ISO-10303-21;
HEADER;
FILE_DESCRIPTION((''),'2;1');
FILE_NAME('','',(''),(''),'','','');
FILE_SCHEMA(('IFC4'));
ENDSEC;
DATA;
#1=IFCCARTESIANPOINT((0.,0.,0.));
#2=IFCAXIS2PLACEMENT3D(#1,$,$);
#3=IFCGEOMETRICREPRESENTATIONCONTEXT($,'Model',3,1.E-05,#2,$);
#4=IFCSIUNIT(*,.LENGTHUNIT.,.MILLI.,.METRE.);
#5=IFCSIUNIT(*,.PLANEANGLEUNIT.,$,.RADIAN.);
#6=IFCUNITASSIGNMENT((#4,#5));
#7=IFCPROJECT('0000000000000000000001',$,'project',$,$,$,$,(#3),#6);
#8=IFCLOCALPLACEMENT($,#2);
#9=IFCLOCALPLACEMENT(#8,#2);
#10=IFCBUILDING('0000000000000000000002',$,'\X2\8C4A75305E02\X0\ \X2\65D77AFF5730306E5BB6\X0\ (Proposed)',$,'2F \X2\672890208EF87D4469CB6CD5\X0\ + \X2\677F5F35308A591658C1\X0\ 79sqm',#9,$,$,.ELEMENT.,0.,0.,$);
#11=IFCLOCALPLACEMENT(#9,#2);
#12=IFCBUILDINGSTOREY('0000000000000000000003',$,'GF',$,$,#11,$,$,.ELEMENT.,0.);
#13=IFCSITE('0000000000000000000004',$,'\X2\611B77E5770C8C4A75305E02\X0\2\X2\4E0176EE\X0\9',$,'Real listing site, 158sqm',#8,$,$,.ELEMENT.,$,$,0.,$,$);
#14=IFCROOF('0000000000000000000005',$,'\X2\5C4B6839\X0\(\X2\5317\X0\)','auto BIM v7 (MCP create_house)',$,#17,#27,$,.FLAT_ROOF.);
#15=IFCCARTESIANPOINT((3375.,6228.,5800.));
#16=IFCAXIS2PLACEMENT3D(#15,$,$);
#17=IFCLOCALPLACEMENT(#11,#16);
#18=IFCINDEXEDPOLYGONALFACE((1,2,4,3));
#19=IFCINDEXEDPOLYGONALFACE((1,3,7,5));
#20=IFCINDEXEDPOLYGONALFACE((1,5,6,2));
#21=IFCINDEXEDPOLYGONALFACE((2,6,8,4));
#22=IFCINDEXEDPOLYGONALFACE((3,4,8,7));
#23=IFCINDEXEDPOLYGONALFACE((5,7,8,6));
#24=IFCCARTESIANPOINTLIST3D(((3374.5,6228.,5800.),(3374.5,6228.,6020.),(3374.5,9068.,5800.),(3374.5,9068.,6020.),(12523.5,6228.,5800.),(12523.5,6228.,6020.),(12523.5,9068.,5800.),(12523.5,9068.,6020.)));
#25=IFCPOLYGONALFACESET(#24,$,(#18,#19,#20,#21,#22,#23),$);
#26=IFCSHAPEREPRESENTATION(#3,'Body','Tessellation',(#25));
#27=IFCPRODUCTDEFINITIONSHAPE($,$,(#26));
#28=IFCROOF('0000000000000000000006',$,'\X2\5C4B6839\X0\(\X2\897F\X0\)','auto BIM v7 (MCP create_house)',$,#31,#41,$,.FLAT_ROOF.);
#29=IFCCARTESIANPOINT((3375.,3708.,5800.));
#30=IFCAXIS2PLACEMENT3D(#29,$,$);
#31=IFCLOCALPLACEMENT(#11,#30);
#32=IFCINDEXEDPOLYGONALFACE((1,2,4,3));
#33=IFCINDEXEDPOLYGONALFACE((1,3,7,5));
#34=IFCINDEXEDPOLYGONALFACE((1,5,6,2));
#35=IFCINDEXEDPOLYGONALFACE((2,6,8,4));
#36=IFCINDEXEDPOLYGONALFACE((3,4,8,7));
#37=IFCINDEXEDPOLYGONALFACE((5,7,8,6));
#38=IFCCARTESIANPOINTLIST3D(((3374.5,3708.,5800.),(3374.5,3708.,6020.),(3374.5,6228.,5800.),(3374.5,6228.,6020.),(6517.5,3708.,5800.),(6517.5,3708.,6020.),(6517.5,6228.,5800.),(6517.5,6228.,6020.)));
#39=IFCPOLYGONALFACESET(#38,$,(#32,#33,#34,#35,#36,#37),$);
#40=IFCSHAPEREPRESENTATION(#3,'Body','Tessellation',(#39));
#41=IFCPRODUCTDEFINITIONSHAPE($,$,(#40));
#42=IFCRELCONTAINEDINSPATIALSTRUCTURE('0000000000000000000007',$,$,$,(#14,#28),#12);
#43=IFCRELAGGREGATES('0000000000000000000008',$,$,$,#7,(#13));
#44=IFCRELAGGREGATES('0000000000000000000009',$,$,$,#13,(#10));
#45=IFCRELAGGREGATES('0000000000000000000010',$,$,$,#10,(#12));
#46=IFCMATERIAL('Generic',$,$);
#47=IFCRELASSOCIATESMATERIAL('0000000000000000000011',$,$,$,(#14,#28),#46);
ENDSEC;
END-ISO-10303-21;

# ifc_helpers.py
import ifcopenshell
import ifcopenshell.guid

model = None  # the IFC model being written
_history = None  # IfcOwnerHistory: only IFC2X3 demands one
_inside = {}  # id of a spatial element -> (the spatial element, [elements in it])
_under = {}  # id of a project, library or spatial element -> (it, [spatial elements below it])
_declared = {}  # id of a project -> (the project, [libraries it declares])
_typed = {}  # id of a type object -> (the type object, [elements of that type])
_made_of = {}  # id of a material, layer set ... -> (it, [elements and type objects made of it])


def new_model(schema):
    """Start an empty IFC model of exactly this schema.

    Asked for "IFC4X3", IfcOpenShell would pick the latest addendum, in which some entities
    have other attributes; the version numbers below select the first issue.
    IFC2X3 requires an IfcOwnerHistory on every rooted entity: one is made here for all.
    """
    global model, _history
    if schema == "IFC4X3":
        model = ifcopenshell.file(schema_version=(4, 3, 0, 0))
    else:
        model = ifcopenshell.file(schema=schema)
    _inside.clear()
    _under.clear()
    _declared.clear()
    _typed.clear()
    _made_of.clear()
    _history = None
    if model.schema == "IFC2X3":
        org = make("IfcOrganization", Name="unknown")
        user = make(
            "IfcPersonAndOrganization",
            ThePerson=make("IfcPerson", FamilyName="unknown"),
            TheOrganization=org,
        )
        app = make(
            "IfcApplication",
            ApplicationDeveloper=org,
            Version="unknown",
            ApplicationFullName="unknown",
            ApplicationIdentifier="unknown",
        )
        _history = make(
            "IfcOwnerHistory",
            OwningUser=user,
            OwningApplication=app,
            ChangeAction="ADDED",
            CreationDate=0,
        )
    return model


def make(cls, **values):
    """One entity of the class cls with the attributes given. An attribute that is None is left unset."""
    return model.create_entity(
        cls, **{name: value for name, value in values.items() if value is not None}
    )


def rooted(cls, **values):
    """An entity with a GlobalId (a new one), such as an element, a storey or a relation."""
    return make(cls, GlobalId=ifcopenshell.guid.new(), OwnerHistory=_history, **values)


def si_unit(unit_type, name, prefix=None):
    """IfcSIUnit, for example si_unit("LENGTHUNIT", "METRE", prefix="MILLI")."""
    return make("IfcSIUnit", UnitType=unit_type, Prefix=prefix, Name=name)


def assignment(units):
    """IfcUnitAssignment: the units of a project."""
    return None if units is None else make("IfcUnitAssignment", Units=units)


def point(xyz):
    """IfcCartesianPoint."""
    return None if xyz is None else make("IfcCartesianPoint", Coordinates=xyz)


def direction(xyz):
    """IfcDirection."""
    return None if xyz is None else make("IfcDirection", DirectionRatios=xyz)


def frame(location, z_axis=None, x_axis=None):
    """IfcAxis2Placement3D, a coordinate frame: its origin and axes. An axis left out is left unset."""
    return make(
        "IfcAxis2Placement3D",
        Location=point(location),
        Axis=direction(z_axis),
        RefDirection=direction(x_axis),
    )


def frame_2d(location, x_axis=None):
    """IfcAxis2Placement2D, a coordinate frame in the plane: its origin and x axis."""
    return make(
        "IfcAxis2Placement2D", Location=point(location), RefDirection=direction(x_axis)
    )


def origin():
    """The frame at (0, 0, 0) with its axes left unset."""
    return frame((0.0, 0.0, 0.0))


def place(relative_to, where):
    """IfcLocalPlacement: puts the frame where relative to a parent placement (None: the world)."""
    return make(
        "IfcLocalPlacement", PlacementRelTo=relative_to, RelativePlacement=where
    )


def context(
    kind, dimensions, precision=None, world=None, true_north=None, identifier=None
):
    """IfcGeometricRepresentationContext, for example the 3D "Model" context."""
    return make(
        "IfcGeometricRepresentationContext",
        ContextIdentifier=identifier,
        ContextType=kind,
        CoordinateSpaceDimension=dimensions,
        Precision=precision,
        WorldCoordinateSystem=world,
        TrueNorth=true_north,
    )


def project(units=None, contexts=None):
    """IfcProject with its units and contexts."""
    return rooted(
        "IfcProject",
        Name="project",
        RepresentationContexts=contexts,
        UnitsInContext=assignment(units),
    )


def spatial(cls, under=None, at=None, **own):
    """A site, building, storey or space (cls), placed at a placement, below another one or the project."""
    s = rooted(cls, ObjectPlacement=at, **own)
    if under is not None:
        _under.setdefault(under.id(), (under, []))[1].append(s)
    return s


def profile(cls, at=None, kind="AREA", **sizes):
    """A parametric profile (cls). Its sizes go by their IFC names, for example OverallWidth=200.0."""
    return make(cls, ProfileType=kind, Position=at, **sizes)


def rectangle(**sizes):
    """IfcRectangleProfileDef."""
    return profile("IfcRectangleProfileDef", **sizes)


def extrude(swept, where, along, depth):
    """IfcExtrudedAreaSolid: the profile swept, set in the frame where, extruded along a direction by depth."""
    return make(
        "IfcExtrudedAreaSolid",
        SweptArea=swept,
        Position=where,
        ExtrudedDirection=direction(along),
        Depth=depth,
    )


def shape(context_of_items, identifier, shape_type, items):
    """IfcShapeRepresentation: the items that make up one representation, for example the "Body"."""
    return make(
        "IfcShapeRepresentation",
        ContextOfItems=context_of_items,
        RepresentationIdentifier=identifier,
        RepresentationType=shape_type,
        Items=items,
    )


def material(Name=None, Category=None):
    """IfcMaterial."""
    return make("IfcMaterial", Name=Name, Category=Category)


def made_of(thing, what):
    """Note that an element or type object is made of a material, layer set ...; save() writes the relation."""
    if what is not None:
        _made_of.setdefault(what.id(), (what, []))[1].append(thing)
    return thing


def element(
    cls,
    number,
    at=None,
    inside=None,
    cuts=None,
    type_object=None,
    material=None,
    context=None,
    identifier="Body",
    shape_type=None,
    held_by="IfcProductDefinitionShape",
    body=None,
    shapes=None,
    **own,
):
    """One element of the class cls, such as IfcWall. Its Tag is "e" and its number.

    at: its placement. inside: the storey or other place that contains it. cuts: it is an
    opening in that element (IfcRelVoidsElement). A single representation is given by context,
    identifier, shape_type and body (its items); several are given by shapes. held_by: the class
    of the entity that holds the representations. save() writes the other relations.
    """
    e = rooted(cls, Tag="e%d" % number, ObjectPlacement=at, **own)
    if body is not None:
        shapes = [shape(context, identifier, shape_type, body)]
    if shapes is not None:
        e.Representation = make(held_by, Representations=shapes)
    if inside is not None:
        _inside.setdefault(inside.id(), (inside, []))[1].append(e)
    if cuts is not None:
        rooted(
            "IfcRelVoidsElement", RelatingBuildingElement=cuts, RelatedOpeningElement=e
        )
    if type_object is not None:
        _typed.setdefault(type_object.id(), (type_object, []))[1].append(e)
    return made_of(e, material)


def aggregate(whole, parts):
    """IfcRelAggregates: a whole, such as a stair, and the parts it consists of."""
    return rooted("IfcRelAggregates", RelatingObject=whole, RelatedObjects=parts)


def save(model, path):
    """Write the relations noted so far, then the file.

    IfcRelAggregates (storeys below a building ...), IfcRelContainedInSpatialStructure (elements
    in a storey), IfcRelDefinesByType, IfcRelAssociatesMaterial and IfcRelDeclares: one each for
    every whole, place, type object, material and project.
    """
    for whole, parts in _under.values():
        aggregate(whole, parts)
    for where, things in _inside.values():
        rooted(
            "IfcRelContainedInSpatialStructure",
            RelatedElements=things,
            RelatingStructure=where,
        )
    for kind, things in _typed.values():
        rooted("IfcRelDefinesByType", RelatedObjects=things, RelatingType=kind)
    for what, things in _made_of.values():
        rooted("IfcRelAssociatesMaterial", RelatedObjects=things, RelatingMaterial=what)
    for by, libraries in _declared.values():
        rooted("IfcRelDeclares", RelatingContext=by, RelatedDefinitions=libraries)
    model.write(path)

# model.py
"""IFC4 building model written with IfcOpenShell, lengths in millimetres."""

from ifc_helpers import new_model, si_unit, frame, frame_2d, origin, place, context, project, spatial, rectangle, extrude, material, element, save


model = new_model("IFC4")

# Units and contexts
model_context = context("Model", 3, precision=1e-05, world=origin())
ifc_project = project(units=[si_unit("LENGTHUNIT", "METRE", prefix="MILLI"), si_unit("PLANEANGLEUNIT", "RADIAN")], contexts=[model_context])

# Site, building, storey
site_placement = place(None, origin())
site = spatial("IfcSite", under=ifc_project, at=site_placement, Name="愛知県豊田市2丁目9", ObjectType="Real listing site, 158sqm", CompositionType="ELEMENT", RefElevation=0.0)
building_placement = place(site_placement, origin())
building = spatial("IfcBuilding", under=site, at=building_placement, Name="豊田市 旗竿地の家 (Proposed)", ObjectType="2F 木造軸組構法 + 板張り外壁 79sqm", CompositionType="ELEMENT", ElevationOfRefHeight=0.0, ElevationOfTerrain=0.0)
storey_placement = place(building_placement, origin())
storey = spatial("IfcBuildingStorey", under=building, at=storey_placement, Name="GF", CompositionType="ELEMENT", Elevation=0.0)

# Shared definitions
ifc_material = material(Name="Generic")

# Roofs
roof_1_placement = place(storey_placement, frame((3375.0, 6228.0, 5800.0)))
element("IfcRoof", 1, at=roof_1_placement, inside=storey, material=ifc_material, Name="屋根(北)", Description="auto BIM v7 (MCP create_house)", PredefinedType="FLAT_ROOF", context=model_context, shape_type="SweptSolid", body=[
    extrude(rectangle(XDim=9149.0, YDim=2840.0, at=frame_2d((4574.0, 1420.0))), frame((3375.0, 6228.0, 5800.0)), (0.0, 0.0, 1.0), 220.0),
])
roof_2_placement = place(storey_placement, frame((3375.0, 3708.0, 5800.0)))
element("IfcRoof", 2, at=roof_2_placement, inside=storey, material=ifc_material, Name="屋根(西)", Description="auto BIM v7 (MCP create_house)", PredefinedType="FLAT_ROOF", context=model_context, shape_type="SweptSolid", body=[
    extrude(rectangle(XDim=3143.0, YDim=2520.0, at=frame_2d((1571.0, 1260.0))), frame((3375.0, 3708.0, 5800.0)), (0.0, 0.0, 1.0), 220.0),
])

save(model, "model.ifc")
